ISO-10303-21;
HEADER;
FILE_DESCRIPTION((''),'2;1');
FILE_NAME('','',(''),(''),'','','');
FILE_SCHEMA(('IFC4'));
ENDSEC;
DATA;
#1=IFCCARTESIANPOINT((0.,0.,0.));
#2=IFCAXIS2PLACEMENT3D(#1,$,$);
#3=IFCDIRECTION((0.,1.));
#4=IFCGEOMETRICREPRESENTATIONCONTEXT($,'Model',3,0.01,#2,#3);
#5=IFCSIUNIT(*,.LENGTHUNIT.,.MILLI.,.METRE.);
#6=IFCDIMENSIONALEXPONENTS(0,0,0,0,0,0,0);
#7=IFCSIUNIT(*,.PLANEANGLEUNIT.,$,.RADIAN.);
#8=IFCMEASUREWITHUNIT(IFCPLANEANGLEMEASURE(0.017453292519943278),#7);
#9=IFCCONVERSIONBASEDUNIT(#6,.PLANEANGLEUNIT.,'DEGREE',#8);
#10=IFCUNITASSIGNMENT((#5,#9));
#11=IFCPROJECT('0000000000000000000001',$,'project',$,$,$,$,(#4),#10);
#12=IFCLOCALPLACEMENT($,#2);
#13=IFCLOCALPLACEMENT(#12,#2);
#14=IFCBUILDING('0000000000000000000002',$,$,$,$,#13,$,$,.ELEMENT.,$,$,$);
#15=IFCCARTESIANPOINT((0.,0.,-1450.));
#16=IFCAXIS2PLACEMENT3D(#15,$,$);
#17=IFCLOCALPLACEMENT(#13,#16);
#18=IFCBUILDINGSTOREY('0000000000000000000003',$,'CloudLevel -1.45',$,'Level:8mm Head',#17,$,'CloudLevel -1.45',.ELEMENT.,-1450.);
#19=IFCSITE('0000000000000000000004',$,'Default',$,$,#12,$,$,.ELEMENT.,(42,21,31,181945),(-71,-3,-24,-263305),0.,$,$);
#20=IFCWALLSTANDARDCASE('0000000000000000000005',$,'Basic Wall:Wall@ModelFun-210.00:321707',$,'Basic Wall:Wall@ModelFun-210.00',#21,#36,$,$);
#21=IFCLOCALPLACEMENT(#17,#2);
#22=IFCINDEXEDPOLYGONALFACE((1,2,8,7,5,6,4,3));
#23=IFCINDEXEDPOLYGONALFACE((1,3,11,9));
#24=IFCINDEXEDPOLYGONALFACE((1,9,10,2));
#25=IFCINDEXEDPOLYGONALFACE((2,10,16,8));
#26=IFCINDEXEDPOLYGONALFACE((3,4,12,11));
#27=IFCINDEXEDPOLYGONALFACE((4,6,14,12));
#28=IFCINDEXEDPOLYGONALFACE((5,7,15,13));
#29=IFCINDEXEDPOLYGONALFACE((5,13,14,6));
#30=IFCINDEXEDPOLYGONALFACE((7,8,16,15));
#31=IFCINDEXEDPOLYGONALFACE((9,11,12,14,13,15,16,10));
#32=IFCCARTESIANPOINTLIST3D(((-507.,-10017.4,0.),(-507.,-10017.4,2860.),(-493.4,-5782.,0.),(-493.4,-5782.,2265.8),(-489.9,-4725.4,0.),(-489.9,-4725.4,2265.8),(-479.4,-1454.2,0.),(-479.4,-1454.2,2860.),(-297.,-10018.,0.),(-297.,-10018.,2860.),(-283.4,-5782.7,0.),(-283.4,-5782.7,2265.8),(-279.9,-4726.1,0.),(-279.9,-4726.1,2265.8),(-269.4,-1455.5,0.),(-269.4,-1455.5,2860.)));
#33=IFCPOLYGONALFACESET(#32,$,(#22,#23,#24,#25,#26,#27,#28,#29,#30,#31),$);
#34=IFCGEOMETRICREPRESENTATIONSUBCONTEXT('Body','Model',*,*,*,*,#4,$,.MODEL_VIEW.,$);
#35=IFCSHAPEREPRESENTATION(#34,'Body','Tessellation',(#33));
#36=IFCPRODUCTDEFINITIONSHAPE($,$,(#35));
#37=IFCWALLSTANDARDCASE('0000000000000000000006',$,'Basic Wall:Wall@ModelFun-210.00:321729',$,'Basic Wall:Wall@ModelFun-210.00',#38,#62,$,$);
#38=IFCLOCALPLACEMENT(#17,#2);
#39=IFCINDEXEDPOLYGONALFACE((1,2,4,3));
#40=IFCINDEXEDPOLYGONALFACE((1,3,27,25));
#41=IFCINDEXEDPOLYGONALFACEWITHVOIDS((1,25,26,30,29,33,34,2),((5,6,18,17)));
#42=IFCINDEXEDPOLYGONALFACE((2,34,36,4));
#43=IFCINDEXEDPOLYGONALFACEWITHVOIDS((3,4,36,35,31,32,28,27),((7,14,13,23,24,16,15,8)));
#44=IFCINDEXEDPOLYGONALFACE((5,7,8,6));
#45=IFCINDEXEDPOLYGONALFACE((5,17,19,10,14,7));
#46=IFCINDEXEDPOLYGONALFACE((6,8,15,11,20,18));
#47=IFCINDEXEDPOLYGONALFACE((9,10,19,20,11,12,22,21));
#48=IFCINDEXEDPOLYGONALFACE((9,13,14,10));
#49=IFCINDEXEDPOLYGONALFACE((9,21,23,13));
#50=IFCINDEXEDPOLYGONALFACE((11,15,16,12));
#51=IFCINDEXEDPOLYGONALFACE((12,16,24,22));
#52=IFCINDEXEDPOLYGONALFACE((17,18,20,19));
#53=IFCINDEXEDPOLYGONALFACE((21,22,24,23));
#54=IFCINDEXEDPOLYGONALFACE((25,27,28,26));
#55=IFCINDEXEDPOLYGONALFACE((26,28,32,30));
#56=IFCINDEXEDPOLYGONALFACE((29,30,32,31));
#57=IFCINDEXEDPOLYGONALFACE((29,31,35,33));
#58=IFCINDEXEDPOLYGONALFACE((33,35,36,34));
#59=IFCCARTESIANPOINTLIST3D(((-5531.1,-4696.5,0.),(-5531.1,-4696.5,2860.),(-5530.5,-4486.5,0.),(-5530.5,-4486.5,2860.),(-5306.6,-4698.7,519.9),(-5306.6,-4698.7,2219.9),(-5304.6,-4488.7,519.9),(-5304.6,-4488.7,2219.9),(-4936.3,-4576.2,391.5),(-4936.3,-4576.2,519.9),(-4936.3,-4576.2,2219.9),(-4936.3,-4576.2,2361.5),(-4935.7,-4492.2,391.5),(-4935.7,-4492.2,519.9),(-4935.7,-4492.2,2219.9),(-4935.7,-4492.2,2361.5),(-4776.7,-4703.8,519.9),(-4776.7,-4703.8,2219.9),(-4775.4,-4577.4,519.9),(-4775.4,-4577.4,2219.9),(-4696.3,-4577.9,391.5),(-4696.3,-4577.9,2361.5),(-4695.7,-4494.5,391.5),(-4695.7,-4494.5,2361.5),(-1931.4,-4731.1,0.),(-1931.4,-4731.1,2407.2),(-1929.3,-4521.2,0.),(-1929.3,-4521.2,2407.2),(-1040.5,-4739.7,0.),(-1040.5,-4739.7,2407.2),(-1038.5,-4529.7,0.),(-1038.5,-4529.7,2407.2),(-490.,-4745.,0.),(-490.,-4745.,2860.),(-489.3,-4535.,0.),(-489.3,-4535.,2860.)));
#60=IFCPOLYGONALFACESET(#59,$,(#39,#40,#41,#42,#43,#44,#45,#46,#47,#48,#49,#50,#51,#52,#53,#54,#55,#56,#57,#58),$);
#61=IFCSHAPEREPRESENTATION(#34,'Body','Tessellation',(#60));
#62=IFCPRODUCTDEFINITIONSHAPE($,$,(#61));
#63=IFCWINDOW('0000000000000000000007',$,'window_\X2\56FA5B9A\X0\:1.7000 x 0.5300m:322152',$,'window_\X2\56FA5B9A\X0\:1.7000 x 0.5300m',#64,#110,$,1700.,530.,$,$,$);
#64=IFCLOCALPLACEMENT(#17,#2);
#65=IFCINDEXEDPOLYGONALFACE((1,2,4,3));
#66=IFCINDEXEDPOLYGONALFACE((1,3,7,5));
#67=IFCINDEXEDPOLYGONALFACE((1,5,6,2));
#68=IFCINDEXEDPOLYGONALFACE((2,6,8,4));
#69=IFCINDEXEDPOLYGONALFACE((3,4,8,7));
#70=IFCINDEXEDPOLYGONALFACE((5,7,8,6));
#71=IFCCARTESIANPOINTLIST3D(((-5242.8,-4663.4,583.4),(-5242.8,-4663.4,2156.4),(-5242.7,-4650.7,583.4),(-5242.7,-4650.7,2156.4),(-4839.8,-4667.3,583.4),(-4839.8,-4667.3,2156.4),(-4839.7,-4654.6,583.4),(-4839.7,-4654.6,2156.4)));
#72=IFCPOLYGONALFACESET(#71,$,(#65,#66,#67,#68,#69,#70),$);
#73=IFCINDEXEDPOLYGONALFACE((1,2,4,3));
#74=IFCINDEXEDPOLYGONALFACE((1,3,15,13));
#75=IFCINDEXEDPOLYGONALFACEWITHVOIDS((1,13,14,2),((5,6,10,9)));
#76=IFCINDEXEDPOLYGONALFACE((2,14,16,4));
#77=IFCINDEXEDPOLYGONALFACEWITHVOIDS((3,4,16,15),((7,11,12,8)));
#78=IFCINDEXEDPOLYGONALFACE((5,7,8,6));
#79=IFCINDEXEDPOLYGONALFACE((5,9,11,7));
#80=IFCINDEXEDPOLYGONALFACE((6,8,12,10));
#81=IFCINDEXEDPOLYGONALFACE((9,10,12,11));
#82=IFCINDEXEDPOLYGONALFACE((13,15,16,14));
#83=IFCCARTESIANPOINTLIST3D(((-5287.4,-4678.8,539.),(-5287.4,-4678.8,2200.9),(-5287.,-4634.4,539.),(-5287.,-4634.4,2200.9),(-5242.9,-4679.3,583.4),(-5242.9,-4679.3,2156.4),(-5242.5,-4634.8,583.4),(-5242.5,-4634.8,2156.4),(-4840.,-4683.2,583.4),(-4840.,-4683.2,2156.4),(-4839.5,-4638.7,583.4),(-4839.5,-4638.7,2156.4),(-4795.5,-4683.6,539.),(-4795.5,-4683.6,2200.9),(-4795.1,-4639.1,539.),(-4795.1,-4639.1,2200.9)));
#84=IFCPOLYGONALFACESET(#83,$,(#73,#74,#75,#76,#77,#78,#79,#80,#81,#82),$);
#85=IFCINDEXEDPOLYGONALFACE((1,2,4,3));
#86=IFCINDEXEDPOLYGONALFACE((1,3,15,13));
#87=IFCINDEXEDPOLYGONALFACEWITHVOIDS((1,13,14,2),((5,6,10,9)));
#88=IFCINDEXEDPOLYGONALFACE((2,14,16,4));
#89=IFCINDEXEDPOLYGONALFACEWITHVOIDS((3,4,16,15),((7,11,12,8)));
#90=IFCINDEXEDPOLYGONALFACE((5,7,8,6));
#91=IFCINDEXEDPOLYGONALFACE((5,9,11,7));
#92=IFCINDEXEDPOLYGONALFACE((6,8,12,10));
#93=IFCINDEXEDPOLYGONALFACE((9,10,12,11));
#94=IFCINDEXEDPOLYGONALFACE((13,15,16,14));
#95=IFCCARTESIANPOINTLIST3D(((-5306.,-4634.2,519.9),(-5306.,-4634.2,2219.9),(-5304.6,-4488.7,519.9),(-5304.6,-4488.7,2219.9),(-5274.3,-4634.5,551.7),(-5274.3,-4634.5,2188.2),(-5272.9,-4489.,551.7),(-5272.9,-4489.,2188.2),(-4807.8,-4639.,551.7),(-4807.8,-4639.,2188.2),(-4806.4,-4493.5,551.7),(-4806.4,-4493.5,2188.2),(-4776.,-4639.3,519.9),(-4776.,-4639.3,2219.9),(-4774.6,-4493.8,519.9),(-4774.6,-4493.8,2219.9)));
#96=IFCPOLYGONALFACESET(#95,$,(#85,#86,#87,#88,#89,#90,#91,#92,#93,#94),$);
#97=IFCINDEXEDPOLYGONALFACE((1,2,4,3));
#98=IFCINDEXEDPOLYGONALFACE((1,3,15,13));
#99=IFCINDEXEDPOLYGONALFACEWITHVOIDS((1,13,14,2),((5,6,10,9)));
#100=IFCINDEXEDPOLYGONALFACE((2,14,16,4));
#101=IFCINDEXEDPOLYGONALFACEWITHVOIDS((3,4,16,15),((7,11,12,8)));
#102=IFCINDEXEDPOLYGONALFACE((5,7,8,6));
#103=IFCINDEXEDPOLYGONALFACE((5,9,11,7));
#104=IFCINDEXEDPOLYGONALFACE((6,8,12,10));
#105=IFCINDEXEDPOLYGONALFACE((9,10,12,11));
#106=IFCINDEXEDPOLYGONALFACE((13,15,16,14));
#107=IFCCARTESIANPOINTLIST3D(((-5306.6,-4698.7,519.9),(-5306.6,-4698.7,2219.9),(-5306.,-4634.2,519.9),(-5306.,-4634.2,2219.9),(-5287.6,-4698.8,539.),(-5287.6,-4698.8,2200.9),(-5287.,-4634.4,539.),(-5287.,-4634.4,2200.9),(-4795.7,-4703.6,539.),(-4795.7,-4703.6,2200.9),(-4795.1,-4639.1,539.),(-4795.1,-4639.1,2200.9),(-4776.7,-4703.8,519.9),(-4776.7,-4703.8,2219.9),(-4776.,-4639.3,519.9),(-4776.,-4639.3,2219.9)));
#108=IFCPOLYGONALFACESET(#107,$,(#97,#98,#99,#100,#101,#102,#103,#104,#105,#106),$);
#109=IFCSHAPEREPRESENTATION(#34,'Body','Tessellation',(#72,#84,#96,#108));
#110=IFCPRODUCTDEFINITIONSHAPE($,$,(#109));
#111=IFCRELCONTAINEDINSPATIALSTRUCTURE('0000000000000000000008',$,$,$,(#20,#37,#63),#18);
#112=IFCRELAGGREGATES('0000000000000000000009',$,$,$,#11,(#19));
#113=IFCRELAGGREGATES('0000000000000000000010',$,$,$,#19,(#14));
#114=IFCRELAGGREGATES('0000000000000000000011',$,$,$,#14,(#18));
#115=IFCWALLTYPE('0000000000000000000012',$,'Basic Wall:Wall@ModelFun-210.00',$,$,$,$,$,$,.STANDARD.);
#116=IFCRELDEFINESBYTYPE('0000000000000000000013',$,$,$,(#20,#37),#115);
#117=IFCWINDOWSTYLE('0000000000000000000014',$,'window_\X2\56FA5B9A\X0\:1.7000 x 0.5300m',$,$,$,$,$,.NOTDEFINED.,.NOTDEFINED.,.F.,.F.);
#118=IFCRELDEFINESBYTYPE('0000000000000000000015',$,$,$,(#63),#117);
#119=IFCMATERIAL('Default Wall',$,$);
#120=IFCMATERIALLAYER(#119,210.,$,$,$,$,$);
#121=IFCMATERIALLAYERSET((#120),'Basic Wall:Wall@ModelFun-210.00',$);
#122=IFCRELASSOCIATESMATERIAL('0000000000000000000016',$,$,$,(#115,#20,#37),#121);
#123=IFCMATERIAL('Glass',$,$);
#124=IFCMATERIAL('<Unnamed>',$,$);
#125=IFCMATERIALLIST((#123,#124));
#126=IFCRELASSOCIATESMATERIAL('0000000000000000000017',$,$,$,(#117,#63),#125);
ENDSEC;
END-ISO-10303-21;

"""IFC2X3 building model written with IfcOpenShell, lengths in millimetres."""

from ifc_helpers import new_model, entity, si_unit, converted_unit, direction, frame, frame_2d, origin, place, context, subcontext, project, spatial, polyline, rectangle, outline, extrude, source, transform, mapped, material, material_list, layer, layer_set, layer_usage, type_object, type_shapes, element, fill, save


model = new_model("IFC2X3")

# Units and contexts
model_context = context("Model", 3, precision=0.01, world=origin(), true_north=direction((0.0, 1.0)))
body_context = subcontext(model_context, "Body", "Model", "MODEL_VIEW")
ifc_project = project(units=[si_unit("LENGTHUNIT", "METRE", prefix="MILLI"), converted_unit("PLANEANGLEUNIT", "DEGREE", entity("IfcPlaneAngleMeasure", 0.017453292519943278), si_unit("PLANEANGLEUNIT", "RADIAN"), dimensions=[0, 0, 0, 0, 0, 0, 0])], contexts=[model_context])

# Site, building, storey
site_placement = place(None, origin())
site = spatial("IfcSite", under=ifc_project, at=site_placement, Name="Default", CompositionType="ELEMENT", RefLatitude=(42, 21, 31, 181945), RefLongitude=(-71, -3, -24, -263305), RefElevation=0.0)
building_placement = place(site_placement, origin())
building = spatial("IfcBuilding", under=site, at=building_placement, CompositionType="ELEMENT")
storey_placement = place(building_placement, frame((0.0, 0.0, -1450.0)))
storey = spatial("IfcBuildingStorey", under=building, at=storey_placement, Name="CloudLevel -1.45", ObjectType="Level:8mm Head", LongName="CloudLevel -1.45", CompositionType="ELEMENT", Elevation=-1450.0)

# Shared definitions
ifc_material_1 = material(Name="Default Wall")
ifc_material_2 = material(Name="Glass")
ifc_material_3 = material(Name="<Unnamed>")
ifc_material_list = material_list([ifc_material_2, ifc_material_3])

# Wall, opening
ifc_layer_1 = layer(ifc_material_1, 210.0)
ifc_layer_set_1 = layer_set([ifc_layer_1], Name="Basic Wall:Wall@ModelFun-210.00")
ifc_layer_usage_1 = layer_usage(ifc_layer_set_1, "AXIS2", "NEGATIVE", 105.0)
wall_type_1 = type_object("IfcWallType", Name="Basic Wall:Wall@ModelFun-210.00", PredefinedType="STANDARD", material=ifc_layer_set_1)
wall_1_placement = place(storey_placement, frame((-374.4, -1454.5, 0.0), z_axis=(0.0, 0.0, 1.0), x_axis=(-0.003223, -0.999995, 0.0)))
wall_1 = element("IfcWallStandardCase", 1, at=wall_1_placement, inside=storey, type_object=wall_type_1, material=ifc_layer_usage_1, Name="Basic Wall:Wall@ModelFun-210.00:321707", ObjectType="Basic Wall:Wall@ModelFun-210.00", context=body_context, shape_type="SweptSolid", body=[
    extrude(outline(polyline([(0.0, -105.0), (190.0, -105.0), (3080.9, -105.0), (3290.9, -105.0), (4331.2, -105.0), (4571.3, -105.0), (6977.8, -105.0), (7217.8, -105.0), (8563.3, -105.0), (8563.2, 105.0), (0.6, 105.0), (0.0, -105.0)])), origin(), (0.0, 0.0, 1.0), 2860.0),
])
opening_1_placement = place(wall_1_placement, frame((3271.3, -105.0, 0.0)))
element("IfcOpeningElement", 2, at=opening_1_placement, cuts=wall_1, ObjectType="Opening", context=body_context, shape_type="SweptSolid", body=[
    extrude(rectangle(XDim=1056.5, YDim=2265.8, at=frame_2d((1132.9, 528.3), x_axis=(0.0, 1.0))), frame((0.0, 0.0, 0.0), z_axis=(0.0, 1.0, 0.0), x_axis=(0.0, 0.0, 1.0)), (0.0, 0.0, 1.0), 210.0),
])

# Wall, openings, window
wall_2_placement = place(storey_placement, frame((-5531.5, -4591.5, 0.0), z_axis=(0.0, 0.0, 1.0), x_axis=(0.999954, -0.009624, 0.0)))
wall_2 = element("IfcWallStandardCase", 3, at=wall_2_placement, inside=storey, type_object=wall_type_1, material=ifc_layer_usage_1, Name="Basic Wall:Wall@ModelFun-210.00:321729", ObjectType="Basic Wall:Wall@ModelFun-210.00", context=body_context, shape_type="SweptSolid", body=[
    extrude(outline(polyline([(1.5, -105.0), (241.5, -105.0), (3339.9, -105.0), (3539.9, -105.0), (5042.8, -105.0), (5041.4, 105.0), (3539.1, 105.0), (3339.1, 105.0), (834.9, 105.0), (594.9, 105.0), (0.0, 105.0), (1.5, -105.0)])), origin(), (0.0, 0.0, 1.0), 2860.0),
])
opening_2_placement = place(wall_2_placement, origin())
element("IfcOpeningElement", 4, at=opening_2_placement, cuts=wall_2, ObjectType="Opening", context=body_context, shape_type="SweptSolid", body=[
    extrude(rectangle(XDim=1970.0, YDim=240.0, at=frame_2d((0.0, 0.0), x_axis=(0.0, 1.0))), frame((715.1, 21.3, 1376.5), z_axis=(-0.002264, 0.999997, 0.0), x_axis=(-0.999997, -0.002264, 0.0)), (0.0, 0.0, 1.0), 2870.0),
])
opening_3_placement = place(wall_2_placement, frame((3601.4, -105.0, -35.4)))
element("IfcOpeningElement", 5, at=opening_3_placement, cuts=wall_2, ObjectType="Opening", context=body_context, shape_type="SweptSolid", body=[
    extrude(rectangle(XDim=890.9, YDim=2442.6, at=frame_2d((1221.3, 445.4), x_axis=(0.0, 1.0))), frame((0.0, 0.0, 0.0), z_axis=(0.0, 1.0, 0.0), x_axis=(0.0, 0.0, 1.0)), (0.0, 0.0, 1.0), 210.0),
])
opening_4_placement = place(wall_2_placement, frame((755.9, 105.0, 519.9)))
opening_4 = element("IfcOpeningElement", 6, at=opening_4_placement, cuts=wall_2, ObjectType="Opening", context=body_context, shape_type="SweptSolid", body=[
    extrude(rectangle(XDim=1700.0, YDim=530.0, at=frame_2d((850.0, 265.0), x_axis=(-1.0, 0.0))), frame((0.0, 0.0, 0.0), z_axis=(0.0, -1.0, 0.0), x_axis=(0.0, 0.0, 1.0)), (0.0, 0.0, 1.0), 210.0),
])
window_style_1 = type_object("IfcWindowStyle", Name="window_固定:1.7000 x 0.5300m", ConstructionType="NOTDEFINED", OperationType="NOTDEFINED", ParameterTakesPrecedence=False, Sizeable=False, material=ifc_material_list)
shared_shape_1 = source(origin(), body_context, "Body", "SweptSolid", [
    extrude(rectangle(XDim=403.0, YDim=12.7, at=frame_2d((0.0, 0.0), x_axis=(1.0, 0.0))), frame((341.2, 167.8, 63.5)), (0.0, 0.0, 1.0), 1573.0),
    extrude(outline(polyline([(-245.9, -830.9), (245.9, -830.9), (245.9, 830.9), (-245.9, 830.9), (-245.9, -830.9)]), holes=[polyline([(-201.5, -786.5), (-201.5, 786.5), (201.5, 786.5), (201.5, -786.5), (-201.5, -786.5)])]), frame((341.2, 190.0, 850.0), z_axis=(0.0, -1.0, 0.0), x_axis=(-1.0, 0.0, 0.0)), (0.0, 0.0, 1.0), 44.4),
    extrude(outline(polyline([(-265.0, -850.0), (265.0, -850.0), (265.0, 850.0), (-265.0, 850.0), (-265.0, -850.0)]), holes=[polyline([(-233.2, -818.2), (-233.2, 818.2), (233.2, 818.2), (233.2, -818.2), (-233.2, -818.2)])]), frame((341.2, 145.5, 850.0), z_axis=(0.0, -1.0, 0.0), x_axis=(-1.0, 0.0, 0.0)), (0.0, 0.0, 1.0), 145.5),
    extrude(outline(polyline([(-850.0, -265.0), (850.0, -265.0), (850.0, 265.0), (-850.0, 265.0), (-850.0, -265.0)]), holes=[polyline([(-830.9, -245.9), (-830.9, 245.9), (830.9, 245.9), (830.9, -245.9), (-830.9, -245.9)])]), frame((341.2, 210.0, 850.0), z_axis=(0.0, -1.0, 0.0), x_axis=(0.0, 0.0, -1.0)), (0.0, 0.0, 1.0), 64.4),
])
type_shapes(window_style_1, [shared_shape_1])
window_1_placement = place(opening_4_placement, frame((76.2, 0.0, 0.0), z_axis=(0.0, 0.0, 1.0), x_axis=(-1.0, 0.0, 0.0)))
window_1 = element("IfcWindow", 7, at=window_1_placement, inside=storey, type_object=window_style_1, material=ifc_material_list, Name="window_固定:1.7000 x 0.5300m:322152", ObjectType="window_固定:1.7000 x 0.5300m", OverallHeight=1700.0, OverallWidth=530.0, context=body_context, shape_type="MappedRepresentation", body=[
    mapped(shared_shape_1, transform((0.0, 0.0, 0.0), scale=1.0)),
])
fill(opening_4, window_1)

save(model, "model.ifc")
